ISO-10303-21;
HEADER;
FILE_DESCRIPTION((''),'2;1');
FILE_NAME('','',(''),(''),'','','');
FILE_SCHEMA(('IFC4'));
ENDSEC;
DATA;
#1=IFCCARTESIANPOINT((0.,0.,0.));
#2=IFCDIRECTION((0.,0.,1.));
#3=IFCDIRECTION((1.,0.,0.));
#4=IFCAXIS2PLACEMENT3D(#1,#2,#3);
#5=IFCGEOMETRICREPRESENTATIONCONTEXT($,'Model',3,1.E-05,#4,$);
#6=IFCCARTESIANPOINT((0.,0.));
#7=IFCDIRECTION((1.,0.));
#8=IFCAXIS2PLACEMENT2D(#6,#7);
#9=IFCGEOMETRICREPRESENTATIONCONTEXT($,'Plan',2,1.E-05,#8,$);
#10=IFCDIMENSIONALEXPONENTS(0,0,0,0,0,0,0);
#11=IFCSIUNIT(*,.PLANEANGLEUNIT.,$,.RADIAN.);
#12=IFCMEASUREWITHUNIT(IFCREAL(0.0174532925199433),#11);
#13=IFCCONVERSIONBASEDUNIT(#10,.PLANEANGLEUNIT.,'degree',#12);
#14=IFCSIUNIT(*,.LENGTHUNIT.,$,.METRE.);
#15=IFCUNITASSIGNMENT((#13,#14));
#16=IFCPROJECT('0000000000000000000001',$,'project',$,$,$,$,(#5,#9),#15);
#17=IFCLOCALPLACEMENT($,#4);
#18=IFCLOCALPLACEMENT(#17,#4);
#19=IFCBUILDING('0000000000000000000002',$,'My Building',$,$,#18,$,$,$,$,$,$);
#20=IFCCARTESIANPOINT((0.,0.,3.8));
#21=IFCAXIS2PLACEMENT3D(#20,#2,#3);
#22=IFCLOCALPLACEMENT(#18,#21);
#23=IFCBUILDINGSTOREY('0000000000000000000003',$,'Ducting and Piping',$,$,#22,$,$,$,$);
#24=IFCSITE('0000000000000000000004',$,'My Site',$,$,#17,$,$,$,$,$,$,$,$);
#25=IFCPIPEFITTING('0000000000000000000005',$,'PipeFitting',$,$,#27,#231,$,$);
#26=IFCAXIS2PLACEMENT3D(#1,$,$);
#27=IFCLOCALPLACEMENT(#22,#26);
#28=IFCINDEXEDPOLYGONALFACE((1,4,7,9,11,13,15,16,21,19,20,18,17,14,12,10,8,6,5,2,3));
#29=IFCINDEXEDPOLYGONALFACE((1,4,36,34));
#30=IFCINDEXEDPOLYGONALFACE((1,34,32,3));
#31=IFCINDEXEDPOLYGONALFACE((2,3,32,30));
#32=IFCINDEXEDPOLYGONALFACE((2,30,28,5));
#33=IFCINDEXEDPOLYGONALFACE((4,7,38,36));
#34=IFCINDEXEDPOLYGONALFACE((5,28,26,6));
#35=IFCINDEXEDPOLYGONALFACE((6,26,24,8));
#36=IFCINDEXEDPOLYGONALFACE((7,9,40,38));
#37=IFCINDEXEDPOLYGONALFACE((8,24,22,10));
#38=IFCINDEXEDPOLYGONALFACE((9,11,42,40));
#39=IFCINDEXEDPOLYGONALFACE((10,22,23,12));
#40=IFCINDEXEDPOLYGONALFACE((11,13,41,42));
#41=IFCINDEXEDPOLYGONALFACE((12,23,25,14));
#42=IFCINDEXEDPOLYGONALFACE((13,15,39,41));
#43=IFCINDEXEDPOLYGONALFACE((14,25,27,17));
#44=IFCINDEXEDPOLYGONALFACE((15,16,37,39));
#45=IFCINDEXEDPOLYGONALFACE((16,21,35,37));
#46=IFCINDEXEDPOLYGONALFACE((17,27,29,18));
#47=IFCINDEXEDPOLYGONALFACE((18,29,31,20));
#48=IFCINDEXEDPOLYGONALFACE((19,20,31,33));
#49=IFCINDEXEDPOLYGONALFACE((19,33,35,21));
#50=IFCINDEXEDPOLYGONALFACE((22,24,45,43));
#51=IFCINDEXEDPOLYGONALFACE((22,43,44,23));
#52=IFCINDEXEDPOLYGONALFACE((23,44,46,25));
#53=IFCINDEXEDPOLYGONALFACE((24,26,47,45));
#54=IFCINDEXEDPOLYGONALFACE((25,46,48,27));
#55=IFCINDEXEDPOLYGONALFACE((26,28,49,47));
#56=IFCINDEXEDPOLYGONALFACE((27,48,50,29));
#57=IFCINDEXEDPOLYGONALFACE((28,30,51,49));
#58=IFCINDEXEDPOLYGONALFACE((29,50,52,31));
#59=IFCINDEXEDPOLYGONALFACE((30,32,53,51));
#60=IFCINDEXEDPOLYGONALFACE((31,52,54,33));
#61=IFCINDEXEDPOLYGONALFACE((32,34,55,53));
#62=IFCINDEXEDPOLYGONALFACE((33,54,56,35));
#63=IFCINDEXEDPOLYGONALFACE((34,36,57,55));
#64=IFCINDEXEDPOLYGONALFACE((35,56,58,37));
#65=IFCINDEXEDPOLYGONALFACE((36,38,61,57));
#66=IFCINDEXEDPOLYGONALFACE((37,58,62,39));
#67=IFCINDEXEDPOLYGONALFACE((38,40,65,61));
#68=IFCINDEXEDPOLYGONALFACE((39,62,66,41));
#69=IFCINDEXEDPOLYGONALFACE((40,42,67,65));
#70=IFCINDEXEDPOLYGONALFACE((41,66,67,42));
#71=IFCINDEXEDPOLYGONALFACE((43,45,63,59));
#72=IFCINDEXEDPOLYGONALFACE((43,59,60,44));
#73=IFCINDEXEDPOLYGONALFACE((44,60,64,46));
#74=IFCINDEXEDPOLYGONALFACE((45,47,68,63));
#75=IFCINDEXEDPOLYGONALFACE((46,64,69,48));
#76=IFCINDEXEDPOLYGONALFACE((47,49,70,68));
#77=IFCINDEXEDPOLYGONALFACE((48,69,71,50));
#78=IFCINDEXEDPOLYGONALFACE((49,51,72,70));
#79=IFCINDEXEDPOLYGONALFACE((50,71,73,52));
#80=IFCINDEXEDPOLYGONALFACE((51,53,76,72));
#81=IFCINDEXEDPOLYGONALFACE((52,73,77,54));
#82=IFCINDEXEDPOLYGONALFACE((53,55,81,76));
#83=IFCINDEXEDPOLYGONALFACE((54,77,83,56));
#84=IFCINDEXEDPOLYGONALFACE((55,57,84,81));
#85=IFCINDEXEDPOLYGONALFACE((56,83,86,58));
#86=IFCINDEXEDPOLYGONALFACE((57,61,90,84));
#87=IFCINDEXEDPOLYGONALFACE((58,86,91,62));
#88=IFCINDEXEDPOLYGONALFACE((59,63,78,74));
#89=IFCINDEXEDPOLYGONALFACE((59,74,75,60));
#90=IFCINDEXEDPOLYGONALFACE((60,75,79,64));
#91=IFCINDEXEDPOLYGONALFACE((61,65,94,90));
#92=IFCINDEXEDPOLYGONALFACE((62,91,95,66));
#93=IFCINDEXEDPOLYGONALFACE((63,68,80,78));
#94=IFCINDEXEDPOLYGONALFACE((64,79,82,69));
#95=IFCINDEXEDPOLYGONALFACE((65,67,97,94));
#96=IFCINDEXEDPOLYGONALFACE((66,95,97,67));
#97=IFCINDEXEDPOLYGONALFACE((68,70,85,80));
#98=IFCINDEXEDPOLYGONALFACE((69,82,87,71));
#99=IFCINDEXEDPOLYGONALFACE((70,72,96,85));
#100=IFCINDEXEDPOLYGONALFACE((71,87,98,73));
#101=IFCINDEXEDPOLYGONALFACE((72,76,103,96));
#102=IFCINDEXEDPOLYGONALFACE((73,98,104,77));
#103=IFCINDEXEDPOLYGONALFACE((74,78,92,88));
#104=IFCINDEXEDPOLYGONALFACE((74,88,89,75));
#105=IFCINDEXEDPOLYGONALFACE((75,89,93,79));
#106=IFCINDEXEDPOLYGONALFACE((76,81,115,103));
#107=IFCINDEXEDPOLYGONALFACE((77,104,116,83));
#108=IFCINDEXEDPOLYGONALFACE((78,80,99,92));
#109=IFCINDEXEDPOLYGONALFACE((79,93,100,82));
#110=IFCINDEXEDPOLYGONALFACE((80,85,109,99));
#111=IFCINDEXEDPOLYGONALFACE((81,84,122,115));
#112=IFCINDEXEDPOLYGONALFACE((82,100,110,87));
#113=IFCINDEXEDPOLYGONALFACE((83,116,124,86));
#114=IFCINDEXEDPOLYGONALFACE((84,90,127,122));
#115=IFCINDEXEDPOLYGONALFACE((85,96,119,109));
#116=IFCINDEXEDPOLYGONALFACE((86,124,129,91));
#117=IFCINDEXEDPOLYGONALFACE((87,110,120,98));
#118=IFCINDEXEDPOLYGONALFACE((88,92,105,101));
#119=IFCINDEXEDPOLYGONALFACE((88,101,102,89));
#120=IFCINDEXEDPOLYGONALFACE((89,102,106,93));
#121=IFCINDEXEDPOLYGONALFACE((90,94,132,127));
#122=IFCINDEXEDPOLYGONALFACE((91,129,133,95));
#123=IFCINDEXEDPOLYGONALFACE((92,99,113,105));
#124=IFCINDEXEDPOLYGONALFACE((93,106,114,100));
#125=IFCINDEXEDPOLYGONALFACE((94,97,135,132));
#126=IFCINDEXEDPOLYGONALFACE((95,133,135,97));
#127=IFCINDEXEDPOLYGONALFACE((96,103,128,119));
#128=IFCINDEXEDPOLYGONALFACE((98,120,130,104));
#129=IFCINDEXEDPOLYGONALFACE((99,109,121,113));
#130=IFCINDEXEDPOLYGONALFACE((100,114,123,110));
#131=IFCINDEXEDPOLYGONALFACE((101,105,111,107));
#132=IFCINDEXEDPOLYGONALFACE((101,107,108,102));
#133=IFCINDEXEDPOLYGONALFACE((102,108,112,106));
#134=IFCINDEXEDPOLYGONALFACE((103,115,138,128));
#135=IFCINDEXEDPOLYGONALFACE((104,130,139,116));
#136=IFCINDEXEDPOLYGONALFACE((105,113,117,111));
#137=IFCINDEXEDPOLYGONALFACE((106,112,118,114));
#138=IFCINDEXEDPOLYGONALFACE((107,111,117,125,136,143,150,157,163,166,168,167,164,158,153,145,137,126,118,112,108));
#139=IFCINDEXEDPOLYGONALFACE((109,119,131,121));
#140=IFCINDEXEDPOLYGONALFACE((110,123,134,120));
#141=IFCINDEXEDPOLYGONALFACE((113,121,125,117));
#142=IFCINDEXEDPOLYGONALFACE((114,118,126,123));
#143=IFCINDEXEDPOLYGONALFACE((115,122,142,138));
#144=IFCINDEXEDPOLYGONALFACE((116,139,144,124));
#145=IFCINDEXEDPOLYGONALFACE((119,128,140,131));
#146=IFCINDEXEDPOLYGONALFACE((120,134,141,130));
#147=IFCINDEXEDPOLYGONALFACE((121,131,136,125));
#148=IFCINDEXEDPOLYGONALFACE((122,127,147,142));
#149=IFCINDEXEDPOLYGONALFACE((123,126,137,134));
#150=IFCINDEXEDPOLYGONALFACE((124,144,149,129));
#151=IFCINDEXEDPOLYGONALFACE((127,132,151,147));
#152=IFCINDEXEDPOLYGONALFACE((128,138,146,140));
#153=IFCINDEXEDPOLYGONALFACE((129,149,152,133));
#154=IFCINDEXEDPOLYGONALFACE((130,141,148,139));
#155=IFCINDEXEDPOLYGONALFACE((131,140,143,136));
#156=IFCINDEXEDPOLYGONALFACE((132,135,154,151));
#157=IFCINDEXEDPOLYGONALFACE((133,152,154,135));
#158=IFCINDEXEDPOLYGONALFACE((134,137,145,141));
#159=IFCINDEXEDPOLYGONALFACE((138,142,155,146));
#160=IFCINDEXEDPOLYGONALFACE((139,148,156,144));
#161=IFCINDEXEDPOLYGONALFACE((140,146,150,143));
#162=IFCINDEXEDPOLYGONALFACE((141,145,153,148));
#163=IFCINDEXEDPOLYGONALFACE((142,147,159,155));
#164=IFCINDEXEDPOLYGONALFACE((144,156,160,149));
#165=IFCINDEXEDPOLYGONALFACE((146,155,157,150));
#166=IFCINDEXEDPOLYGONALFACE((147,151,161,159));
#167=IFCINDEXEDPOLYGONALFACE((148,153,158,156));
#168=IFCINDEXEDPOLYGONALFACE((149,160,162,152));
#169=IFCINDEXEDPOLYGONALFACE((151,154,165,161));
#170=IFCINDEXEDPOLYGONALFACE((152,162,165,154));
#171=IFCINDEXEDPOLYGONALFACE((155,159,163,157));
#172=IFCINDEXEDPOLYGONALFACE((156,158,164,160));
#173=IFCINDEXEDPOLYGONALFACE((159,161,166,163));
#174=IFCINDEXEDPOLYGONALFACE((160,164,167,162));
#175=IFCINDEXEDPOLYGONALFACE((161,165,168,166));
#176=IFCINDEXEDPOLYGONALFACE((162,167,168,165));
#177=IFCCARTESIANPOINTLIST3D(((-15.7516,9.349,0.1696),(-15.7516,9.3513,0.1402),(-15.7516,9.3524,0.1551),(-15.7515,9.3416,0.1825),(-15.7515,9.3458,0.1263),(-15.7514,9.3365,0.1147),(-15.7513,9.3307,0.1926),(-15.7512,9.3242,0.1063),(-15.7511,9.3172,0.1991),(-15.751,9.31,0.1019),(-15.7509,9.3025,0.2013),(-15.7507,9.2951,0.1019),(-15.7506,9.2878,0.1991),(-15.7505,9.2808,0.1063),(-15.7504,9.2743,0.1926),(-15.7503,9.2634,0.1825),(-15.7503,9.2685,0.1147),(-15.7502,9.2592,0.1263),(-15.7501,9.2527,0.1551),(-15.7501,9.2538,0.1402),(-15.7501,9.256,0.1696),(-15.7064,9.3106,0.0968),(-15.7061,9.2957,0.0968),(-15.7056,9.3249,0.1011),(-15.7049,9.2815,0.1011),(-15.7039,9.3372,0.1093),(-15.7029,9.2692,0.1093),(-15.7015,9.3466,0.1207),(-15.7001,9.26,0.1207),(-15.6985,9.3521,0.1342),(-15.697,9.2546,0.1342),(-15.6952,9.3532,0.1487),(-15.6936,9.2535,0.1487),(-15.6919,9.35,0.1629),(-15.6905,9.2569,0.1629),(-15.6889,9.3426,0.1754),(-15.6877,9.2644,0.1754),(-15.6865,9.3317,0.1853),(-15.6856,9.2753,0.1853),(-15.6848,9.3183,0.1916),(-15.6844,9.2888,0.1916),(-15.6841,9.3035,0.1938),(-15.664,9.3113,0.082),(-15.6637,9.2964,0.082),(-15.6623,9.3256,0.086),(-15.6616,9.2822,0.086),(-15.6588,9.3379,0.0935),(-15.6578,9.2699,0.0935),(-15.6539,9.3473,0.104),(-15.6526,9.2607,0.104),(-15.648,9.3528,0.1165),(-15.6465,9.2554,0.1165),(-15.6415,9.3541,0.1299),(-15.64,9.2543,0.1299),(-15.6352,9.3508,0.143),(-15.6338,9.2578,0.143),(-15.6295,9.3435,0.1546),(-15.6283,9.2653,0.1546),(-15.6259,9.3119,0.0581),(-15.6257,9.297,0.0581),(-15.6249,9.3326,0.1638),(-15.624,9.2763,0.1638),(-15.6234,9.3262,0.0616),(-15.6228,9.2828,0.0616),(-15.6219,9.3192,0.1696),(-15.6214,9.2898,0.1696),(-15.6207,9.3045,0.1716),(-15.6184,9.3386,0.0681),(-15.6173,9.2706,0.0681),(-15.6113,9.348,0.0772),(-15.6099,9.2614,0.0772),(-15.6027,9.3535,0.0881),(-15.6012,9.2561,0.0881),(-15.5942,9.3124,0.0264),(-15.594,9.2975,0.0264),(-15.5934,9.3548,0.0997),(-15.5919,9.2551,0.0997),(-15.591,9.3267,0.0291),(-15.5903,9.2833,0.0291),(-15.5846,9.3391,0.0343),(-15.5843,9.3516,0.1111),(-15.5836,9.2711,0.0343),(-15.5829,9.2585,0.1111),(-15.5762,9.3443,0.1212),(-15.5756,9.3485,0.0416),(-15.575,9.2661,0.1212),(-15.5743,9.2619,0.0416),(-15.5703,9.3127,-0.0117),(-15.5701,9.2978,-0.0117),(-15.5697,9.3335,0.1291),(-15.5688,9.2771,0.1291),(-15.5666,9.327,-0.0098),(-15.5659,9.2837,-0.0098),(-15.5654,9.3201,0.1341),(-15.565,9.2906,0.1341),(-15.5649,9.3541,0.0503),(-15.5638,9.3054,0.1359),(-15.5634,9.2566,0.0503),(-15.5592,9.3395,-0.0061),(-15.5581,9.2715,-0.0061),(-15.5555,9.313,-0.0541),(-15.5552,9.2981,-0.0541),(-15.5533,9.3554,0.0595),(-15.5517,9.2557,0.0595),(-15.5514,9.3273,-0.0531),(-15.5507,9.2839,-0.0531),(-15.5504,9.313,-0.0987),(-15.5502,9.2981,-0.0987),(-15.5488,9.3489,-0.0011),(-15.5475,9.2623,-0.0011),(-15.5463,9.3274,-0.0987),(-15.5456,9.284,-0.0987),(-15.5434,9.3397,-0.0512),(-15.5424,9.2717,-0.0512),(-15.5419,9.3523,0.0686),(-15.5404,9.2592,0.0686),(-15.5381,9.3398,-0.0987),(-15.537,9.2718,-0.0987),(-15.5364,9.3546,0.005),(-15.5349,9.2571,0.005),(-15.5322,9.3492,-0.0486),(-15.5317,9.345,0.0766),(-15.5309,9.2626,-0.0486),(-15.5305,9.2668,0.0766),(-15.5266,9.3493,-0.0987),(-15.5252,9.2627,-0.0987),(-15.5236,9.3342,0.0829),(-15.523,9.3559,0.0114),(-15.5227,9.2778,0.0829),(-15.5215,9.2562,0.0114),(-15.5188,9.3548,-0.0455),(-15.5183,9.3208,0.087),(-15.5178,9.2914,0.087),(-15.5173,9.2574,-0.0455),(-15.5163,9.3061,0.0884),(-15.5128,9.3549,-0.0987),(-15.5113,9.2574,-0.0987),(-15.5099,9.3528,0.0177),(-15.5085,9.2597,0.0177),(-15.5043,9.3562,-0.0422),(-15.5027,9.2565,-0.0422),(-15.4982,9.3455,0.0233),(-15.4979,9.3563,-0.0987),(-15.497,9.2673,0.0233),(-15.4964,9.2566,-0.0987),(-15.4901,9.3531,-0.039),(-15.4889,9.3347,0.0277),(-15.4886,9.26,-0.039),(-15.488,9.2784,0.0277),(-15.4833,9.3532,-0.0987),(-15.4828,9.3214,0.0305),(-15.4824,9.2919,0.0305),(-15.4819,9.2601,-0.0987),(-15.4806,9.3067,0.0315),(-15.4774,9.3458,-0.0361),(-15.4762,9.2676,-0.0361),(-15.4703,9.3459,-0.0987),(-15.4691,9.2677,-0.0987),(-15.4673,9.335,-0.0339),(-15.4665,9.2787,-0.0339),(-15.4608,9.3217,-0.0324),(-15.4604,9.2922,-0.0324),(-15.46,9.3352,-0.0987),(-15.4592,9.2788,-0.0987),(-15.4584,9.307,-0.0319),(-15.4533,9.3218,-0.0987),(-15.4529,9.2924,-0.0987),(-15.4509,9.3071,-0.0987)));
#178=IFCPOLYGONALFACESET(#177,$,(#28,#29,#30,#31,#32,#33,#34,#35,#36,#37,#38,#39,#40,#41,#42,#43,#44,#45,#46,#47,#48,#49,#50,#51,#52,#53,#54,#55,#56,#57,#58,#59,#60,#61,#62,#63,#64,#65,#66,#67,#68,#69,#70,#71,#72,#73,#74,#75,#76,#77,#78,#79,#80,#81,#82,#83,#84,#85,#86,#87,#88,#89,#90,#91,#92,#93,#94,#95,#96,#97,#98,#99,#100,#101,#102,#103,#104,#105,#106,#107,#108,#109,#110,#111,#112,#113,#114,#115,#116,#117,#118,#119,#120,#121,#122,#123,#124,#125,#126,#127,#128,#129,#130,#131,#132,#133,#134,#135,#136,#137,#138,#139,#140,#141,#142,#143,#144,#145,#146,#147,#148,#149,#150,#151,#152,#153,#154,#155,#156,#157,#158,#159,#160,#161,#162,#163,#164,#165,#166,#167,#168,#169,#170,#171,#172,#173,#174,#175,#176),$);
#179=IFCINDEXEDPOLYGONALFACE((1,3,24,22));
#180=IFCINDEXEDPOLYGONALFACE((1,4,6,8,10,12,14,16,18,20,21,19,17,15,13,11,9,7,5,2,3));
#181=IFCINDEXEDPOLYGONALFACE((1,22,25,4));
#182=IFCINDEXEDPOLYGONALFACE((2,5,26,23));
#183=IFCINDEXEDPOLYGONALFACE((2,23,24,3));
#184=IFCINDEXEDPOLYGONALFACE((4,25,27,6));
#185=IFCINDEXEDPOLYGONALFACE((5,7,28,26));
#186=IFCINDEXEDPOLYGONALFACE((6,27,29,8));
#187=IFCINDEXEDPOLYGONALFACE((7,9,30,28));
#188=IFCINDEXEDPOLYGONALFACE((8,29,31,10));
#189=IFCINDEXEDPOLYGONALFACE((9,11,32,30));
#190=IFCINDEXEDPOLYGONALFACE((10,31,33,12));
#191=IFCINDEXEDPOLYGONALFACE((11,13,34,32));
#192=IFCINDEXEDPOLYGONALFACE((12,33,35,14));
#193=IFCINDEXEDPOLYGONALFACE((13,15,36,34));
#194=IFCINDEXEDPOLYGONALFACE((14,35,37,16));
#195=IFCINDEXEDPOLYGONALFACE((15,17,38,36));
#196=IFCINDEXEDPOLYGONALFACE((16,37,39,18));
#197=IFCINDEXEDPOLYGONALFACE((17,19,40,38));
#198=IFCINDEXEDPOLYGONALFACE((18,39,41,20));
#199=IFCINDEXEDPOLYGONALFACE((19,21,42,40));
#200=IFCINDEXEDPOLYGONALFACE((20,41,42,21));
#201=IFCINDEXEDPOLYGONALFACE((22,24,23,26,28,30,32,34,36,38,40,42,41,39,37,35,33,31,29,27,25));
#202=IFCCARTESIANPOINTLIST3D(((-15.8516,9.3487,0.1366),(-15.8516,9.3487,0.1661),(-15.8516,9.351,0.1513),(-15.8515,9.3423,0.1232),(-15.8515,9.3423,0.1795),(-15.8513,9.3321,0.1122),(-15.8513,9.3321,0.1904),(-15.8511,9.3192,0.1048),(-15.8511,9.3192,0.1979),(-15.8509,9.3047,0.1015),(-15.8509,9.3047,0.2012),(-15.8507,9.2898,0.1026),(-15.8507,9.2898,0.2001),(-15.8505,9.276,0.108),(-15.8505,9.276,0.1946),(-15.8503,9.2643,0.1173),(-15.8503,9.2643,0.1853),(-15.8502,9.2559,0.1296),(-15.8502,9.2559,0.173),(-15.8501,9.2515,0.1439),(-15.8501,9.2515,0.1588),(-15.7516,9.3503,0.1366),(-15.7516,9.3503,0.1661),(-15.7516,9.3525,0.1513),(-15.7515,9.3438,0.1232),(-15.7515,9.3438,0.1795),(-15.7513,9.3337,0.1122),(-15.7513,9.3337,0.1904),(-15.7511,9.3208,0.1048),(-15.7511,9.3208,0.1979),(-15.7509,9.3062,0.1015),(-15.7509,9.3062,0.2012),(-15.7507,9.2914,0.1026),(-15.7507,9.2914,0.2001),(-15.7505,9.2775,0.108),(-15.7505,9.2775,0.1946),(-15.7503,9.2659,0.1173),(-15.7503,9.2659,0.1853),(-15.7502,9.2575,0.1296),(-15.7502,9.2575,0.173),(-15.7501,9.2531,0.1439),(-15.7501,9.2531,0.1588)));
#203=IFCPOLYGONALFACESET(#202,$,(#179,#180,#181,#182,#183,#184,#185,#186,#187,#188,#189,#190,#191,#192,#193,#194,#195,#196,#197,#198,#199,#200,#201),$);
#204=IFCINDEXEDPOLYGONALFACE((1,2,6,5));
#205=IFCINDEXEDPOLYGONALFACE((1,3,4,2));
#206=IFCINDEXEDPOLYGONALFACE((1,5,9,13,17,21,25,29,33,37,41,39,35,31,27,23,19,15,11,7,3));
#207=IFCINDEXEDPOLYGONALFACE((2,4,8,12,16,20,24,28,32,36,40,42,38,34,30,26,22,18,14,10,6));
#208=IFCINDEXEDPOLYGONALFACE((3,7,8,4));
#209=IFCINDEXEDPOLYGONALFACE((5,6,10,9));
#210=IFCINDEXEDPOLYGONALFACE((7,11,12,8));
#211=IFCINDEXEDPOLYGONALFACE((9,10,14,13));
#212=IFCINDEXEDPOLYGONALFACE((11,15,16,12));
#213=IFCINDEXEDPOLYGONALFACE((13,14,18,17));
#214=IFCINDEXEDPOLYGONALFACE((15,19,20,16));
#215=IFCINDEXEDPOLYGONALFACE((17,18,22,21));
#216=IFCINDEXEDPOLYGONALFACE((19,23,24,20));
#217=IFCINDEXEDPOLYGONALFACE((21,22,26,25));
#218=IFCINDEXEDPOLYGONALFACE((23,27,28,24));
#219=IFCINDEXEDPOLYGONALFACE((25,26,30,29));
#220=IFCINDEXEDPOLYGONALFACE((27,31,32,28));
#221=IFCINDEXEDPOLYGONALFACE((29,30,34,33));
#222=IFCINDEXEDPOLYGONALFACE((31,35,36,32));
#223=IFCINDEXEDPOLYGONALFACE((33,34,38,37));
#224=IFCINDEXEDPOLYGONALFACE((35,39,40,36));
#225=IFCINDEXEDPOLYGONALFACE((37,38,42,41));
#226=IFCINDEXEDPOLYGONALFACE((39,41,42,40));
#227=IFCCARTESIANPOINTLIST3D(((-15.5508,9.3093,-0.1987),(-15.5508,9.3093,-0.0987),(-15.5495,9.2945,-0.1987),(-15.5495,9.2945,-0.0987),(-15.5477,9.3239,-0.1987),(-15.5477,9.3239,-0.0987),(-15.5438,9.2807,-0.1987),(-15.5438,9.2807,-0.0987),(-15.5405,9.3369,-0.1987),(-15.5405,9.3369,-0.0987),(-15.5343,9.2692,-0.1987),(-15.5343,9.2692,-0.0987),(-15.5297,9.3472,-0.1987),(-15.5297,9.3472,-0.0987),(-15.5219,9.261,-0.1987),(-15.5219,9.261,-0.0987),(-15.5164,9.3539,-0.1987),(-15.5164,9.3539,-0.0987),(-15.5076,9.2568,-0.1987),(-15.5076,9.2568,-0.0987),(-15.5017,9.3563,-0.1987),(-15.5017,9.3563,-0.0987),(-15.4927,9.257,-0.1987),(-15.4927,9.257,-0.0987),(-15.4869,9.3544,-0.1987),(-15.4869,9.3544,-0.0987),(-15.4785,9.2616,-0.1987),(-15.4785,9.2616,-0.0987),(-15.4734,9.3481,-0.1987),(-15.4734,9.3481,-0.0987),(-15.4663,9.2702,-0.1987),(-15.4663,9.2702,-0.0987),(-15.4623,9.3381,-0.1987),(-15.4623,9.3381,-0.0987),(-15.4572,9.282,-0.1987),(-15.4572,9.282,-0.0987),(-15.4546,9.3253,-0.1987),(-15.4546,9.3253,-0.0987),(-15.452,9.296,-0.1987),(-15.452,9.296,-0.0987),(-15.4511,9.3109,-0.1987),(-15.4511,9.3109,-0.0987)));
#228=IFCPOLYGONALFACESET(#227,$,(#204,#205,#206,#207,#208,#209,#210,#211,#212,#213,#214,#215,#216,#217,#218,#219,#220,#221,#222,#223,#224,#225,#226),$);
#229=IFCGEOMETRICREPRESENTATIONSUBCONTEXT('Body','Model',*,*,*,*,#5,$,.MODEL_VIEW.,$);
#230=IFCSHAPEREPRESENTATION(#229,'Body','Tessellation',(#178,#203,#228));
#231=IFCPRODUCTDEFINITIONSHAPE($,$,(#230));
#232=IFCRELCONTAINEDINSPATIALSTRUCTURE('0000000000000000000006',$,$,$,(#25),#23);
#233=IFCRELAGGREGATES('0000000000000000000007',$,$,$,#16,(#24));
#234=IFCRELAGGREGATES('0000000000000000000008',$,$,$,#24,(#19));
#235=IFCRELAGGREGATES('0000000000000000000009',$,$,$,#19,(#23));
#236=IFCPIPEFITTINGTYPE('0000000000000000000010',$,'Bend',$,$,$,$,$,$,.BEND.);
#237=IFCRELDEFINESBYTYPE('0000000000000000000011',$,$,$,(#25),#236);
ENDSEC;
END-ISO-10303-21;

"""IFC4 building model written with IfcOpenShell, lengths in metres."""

from ifc_helpers import new_model, entity, si_unit, converted_unit, frame, origin_with_axes, origin_2d_with_axis, place, context, subcontext, project, spatial, circle, extrude, source, transform, mapped, type_object, type_shapes, element, save


model = new_model("IFC4")

# Units and contexts
model_context = context("Model", 3, precision=1e-05, world=origin_with_axes())
plan_context = context("Plan", 2, precision=1e-05, world=origin_2d_with_axis())
body_context = subcontext(model_context, "Body", "Model", "MODEL_VIEW")
ifc_project = project(units=[converted_unit("PLANEANGLEUNIT", "degree", entity("IfcReal", 0.0174532925199433), si_unit("PLANEANGLEUNIT", "RADIAN"), dimensions=[0, 0, 0, 0, 0, 0, 0]), si_unit("LENGTHUNIT", "METRE")], contexts=[model_context, plan_context])

# Site, building, storey
site_placement = place(None, origin_with_axes())
site = spatial("IfcSite", under=ifc_project, at=site_placement, Name="My Site")
building_placement = place(site_placement, origin_with_axes())
building = spatial("IfcBuilding", under=site, at=building_placement, Name="My Building")
storey_placement = place(building_placement, frame((0.0, 0.0, 3.8), z_axis=(0.0, 0.0, 1.0), x_axis=(1.0, 0.0, 0.0)))
storey = spatial("IfcBuildingStorey", under=building, at=storey_placement, Name="Ducting and Piping")

# Pipe fitting
pipe_fitting_type = type_object("IfcPipeFittingType", Name="Bend", PredefinedType="BEND")
shared_shape = source(origin_with_axes(), body_context, "Body", "SolidModel", [
    entity("IfcSweptDiskSolid", entity("IfcIndexedPolyCurve", entity("IfcCartesianPointList3D", [[0.0, 0.0, 0.1], [0.0, -0.0732, 0.2768], [0.0, -0.25, 0.35]]), [entity("IfcArcIndex", [1, 2, 3])]), 0.05),
    extrude(circle(Radius=0.05), origin_with_axes(), (0.0, 0.0, 1.0), 0.1),
    extrude(circle(Radius=0.05), frame((0.0, -0.25, 0.35), z_axis=(0.0, -1.0, 0.0), x_axis=(1.0, 0.0, 0.0)), (0.0, 0.0, 1.0), 0.1),
])
type_shapes(pipe_fitting_type, [shared_shape])
for number, where, z_axis, x_axis, name in (
    (1, (-15.8508, 9.301, 0.1513), (0.999882, 0.015371, 0.0), (-0.015371, 0.999882, 0.0), "PipeFitting"),
):
    element("IfcPipeFitting", number, at=place(storey_placement, frame(where, z_axis=z_axis, x_axis=x_axis)), inside=storey, type_object=pipe_fitting_type, Name=name, context=body_context, shape_type="MappedRepresentation", body=[
        mapped(shared_shape, transform((0.0, 0.0, 0.0), x_axis=(1.0, 0.0, 0.0), y_axis=(0.0, 1.0, 0.0), z_axis=(0.0, 0.0, 1.0), scale=1.0)),
    ])

save(model, "model.ifc")
